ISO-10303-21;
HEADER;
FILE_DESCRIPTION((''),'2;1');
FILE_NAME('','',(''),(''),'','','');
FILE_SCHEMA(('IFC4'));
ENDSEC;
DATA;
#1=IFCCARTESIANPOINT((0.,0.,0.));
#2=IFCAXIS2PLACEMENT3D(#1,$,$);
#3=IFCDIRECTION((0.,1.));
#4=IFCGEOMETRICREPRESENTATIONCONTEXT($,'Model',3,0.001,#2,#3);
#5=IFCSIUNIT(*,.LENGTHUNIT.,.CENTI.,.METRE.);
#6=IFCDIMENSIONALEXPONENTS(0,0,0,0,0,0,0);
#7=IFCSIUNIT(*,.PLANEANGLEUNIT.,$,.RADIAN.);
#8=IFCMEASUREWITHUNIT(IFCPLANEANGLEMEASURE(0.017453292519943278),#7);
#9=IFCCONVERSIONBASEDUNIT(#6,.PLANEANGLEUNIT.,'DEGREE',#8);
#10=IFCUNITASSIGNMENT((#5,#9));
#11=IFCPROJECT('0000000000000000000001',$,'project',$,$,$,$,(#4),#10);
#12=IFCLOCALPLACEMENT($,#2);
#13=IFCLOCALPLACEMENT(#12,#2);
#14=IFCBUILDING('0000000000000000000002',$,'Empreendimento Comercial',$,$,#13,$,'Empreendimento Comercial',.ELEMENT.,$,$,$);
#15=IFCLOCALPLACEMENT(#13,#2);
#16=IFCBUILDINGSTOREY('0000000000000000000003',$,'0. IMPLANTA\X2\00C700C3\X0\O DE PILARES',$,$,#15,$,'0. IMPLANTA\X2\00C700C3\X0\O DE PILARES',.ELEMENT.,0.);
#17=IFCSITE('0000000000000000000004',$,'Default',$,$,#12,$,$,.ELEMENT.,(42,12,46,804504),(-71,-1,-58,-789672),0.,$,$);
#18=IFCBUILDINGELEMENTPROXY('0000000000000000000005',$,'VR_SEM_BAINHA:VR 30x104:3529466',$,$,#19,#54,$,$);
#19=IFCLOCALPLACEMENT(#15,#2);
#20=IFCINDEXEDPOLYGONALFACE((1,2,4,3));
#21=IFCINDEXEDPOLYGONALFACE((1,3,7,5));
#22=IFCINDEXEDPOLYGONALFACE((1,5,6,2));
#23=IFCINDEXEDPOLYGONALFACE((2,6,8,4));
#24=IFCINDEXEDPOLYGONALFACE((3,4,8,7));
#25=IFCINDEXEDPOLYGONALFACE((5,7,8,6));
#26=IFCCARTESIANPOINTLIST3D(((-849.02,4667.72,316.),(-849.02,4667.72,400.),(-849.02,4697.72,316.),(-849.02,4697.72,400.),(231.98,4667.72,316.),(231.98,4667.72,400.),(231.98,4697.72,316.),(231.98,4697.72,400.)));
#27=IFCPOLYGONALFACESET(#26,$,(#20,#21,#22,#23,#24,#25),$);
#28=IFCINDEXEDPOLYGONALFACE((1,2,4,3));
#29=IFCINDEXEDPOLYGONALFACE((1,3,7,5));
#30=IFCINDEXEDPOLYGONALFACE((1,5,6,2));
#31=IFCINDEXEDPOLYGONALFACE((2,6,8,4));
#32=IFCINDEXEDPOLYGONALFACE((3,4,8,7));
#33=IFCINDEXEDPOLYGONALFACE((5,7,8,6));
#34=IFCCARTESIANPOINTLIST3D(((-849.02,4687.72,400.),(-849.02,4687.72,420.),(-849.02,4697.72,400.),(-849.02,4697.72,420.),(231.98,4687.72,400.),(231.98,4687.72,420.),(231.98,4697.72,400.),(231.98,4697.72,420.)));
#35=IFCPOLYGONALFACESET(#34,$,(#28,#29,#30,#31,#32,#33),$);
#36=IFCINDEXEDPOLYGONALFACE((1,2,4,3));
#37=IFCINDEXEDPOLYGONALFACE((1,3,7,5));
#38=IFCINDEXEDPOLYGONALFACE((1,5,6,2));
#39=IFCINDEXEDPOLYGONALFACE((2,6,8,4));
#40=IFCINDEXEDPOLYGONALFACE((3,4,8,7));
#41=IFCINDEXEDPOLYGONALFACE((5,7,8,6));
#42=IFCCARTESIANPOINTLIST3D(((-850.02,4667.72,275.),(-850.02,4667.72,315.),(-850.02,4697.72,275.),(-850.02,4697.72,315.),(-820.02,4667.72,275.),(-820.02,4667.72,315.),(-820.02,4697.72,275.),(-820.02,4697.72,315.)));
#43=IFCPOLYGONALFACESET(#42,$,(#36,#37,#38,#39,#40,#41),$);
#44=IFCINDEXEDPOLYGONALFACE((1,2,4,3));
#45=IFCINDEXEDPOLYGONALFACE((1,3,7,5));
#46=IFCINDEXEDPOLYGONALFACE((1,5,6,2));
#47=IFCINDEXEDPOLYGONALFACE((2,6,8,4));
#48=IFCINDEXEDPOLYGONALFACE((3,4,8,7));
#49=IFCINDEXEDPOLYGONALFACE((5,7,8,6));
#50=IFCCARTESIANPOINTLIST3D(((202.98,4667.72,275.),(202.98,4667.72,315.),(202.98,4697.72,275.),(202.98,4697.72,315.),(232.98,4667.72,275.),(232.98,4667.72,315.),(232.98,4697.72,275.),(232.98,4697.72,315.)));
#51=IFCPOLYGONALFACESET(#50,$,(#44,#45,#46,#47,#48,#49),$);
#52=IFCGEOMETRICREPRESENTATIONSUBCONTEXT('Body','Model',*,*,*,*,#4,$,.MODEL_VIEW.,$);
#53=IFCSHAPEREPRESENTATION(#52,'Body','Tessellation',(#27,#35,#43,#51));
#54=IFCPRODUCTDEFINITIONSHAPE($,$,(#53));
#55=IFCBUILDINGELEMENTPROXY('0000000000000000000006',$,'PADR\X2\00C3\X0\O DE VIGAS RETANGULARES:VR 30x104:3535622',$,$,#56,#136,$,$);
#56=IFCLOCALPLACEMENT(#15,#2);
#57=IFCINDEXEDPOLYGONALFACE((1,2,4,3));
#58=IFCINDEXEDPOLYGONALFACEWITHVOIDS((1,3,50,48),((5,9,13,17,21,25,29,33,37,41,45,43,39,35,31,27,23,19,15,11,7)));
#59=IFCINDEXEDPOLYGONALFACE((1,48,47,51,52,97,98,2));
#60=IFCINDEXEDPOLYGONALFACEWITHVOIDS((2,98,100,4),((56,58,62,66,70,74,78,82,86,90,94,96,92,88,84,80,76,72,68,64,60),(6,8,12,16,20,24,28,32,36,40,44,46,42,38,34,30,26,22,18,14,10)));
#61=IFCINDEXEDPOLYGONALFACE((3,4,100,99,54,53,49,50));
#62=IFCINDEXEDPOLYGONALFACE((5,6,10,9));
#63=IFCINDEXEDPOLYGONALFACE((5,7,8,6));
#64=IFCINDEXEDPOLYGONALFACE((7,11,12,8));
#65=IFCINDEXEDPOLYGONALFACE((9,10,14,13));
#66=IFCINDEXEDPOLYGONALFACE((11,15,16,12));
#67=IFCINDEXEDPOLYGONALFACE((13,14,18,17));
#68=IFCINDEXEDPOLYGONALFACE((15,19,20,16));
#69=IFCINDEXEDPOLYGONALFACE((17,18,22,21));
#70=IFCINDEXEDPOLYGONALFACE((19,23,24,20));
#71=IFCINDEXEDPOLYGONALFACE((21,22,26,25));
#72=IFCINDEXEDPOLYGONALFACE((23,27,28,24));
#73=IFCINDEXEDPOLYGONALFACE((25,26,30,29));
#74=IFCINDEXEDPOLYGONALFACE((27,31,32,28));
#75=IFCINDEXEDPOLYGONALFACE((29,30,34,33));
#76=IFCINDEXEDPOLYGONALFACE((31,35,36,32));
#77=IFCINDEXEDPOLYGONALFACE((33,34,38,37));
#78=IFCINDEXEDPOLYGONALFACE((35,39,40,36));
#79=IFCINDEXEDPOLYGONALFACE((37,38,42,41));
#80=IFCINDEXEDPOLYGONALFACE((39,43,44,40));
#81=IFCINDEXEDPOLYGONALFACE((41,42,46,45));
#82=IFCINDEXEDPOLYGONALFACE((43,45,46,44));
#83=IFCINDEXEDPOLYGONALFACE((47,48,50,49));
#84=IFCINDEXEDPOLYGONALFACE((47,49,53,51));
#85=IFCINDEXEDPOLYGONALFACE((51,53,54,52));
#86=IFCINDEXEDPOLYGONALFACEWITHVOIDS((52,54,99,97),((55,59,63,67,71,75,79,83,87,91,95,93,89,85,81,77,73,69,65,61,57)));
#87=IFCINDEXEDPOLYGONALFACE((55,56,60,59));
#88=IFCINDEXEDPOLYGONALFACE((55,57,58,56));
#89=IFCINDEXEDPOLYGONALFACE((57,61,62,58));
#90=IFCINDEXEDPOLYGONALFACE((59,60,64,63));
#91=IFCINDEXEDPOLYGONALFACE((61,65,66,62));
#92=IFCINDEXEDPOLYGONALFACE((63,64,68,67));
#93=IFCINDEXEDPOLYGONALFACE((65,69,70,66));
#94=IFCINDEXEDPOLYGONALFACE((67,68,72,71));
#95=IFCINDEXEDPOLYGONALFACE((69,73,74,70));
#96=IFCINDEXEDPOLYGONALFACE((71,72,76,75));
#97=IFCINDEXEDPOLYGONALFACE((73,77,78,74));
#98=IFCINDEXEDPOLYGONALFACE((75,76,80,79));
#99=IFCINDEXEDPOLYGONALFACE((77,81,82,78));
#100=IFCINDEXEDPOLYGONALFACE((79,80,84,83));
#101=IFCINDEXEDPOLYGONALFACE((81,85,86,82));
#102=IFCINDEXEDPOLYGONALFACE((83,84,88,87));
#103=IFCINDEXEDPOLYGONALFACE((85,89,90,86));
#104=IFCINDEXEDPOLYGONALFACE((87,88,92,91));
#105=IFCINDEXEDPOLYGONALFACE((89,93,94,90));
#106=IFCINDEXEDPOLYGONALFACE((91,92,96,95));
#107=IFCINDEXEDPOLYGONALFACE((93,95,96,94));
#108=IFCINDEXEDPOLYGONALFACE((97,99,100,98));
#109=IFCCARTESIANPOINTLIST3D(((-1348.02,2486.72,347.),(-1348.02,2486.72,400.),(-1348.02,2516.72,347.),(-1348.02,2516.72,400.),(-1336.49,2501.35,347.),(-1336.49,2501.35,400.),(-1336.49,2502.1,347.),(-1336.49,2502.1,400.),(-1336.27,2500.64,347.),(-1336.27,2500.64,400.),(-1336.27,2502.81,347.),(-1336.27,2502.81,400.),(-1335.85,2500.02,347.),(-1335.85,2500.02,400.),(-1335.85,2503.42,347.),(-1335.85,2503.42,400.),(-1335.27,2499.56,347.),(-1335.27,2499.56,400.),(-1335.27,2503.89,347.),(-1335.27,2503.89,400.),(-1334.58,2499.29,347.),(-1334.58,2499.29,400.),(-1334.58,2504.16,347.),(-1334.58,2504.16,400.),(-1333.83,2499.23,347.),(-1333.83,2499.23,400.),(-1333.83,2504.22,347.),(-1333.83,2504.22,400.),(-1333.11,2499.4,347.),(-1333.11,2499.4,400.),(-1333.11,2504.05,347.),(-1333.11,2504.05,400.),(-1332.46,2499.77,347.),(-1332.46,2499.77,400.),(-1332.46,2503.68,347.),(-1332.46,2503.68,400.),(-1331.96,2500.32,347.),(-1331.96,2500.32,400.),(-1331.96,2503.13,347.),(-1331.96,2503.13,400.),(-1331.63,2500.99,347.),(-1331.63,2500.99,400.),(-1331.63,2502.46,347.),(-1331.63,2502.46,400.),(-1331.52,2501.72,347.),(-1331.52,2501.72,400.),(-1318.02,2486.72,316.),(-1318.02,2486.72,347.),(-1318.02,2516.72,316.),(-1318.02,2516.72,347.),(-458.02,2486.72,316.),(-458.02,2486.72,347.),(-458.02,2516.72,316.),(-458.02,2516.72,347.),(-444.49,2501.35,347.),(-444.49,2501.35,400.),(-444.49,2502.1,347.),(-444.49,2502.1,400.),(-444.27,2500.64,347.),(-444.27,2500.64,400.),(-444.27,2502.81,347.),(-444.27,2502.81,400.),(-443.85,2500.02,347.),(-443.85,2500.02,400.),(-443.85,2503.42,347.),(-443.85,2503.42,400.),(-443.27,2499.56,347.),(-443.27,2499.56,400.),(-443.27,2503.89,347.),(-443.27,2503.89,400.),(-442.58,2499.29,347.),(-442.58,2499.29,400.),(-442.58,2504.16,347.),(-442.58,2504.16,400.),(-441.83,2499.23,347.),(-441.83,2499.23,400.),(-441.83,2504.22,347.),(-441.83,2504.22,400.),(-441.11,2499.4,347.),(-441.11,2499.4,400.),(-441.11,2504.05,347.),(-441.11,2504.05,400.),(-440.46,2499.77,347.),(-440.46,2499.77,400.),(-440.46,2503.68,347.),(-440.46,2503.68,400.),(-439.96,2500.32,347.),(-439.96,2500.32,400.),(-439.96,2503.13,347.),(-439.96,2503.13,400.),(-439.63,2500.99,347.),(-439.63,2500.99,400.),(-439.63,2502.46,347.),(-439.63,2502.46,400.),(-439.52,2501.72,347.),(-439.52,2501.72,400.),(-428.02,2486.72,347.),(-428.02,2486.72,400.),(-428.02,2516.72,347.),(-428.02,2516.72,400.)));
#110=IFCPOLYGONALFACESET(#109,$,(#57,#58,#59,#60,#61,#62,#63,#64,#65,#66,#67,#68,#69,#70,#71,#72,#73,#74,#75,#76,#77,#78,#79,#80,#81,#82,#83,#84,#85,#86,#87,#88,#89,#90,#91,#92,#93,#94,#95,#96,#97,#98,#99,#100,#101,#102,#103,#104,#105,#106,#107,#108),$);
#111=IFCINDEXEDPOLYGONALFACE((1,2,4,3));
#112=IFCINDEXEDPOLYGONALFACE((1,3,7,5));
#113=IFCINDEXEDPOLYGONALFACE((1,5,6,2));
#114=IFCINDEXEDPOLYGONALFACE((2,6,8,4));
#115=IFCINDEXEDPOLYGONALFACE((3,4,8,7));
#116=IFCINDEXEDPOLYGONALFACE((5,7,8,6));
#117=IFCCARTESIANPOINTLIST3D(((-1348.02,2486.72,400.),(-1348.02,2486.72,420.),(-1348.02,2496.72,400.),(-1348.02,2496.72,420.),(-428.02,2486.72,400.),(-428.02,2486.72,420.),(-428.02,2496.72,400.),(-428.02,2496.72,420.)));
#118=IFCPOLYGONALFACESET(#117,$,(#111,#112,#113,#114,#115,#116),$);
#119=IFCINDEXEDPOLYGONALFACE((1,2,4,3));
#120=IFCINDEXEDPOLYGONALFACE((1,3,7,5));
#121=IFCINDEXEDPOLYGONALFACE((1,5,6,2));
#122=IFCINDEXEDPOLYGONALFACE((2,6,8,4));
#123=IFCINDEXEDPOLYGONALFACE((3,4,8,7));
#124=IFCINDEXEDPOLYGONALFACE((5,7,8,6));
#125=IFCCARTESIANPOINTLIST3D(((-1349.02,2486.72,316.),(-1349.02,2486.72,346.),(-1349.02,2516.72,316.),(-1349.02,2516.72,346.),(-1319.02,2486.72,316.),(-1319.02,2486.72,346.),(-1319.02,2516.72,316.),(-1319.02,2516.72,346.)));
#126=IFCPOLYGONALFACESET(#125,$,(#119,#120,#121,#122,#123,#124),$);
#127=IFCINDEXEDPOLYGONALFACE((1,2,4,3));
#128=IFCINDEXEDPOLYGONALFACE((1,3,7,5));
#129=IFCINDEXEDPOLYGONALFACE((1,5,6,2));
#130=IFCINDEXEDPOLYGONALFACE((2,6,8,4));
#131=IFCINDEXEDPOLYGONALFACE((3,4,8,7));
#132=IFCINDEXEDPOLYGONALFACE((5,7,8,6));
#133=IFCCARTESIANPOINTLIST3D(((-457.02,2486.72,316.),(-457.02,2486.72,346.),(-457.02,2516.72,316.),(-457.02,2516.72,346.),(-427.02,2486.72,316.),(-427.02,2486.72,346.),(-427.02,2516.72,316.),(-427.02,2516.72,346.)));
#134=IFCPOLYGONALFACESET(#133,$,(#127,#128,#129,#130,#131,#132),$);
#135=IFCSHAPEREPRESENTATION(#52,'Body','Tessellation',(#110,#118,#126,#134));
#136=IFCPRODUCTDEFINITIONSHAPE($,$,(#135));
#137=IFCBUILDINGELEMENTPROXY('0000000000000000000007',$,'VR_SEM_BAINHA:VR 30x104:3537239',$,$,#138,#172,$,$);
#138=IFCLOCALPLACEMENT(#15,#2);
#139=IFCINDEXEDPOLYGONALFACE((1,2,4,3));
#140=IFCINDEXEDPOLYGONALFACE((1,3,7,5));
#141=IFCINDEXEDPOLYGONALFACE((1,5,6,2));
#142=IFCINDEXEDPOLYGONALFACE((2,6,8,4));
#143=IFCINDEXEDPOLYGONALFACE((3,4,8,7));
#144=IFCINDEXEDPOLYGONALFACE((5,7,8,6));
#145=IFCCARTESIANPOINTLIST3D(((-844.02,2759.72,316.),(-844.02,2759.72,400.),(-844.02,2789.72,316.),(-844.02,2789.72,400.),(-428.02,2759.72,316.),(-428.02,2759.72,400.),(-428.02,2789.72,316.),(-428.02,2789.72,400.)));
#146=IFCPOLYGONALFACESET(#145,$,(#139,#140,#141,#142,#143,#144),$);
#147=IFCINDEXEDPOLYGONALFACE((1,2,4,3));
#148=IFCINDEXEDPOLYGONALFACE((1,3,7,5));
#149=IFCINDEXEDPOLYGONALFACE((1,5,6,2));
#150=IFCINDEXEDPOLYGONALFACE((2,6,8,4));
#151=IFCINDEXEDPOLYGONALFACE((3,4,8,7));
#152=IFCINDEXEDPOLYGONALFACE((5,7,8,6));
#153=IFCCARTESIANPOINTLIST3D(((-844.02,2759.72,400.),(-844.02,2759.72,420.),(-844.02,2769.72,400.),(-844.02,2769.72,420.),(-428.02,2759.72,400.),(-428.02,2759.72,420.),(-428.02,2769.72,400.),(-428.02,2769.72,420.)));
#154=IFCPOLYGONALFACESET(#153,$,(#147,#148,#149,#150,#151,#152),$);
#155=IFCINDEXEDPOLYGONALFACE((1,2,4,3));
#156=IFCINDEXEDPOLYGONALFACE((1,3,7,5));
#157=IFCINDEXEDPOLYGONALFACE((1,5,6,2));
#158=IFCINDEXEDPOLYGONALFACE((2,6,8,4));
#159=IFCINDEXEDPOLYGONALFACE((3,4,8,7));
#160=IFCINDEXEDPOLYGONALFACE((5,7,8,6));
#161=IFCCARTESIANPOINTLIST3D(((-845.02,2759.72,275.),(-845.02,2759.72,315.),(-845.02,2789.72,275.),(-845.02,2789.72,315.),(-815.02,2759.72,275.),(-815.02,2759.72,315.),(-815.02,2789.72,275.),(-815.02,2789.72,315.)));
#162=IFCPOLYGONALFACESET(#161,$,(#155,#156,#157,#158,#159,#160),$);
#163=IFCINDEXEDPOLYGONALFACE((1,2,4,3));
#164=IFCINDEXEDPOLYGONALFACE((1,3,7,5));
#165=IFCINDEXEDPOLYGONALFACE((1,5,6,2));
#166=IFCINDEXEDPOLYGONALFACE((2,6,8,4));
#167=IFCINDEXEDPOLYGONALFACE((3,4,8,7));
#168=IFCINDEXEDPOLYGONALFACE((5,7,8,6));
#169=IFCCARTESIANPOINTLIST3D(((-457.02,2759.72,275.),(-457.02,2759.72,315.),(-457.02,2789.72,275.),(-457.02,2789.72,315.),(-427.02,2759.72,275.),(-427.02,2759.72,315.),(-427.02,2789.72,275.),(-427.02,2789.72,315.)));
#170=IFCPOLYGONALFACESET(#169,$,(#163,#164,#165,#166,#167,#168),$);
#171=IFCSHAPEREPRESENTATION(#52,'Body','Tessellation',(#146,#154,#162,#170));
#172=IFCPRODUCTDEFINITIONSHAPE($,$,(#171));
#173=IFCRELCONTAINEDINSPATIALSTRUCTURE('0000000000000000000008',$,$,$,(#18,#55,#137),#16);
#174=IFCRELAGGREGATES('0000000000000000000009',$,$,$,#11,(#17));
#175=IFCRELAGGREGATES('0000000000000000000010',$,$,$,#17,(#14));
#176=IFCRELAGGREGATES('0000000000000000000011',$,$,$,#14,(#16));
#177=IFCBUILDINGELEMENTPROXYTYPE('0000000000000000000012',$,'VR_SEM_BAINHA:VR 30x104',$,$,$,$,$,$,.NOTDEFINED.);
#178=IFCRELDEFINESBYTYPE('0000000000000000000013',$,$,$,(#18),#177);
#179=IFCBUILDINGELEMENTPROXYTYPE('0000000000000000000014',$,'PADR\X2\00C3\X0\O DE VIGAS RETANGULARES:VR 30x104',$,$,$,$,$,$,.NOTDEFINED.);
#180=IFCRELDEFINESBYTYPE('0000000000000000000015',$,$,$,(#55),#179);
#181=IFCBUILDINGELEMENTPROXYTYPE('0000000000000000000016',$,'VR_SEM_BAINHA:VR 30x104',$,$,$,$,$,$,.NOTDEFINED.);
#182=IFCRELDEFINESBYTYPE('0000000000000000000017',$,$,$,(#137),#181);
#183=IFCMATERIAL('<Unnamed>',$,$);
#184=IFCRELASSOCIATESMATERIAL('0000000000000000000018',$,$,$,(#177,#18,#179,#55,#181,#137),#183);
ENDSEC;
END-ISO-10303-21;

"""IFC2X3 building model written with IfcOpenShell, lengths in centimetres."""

from ifc_helpers import new_model, entity, si_unit, converted_unit, direction, frame, frame_2d, origin, origin_2d_with_axis, place, context, subcontext, project, spatial, polyline, rectangle, circle, outline, extrude, source, transform, mapped, material, type_object, type_shapes, element, save


model = new_model("IFC2X3")

# Units and contexts
model_context = context("Model", 3, precision=0.001, world=origin(), true_north=direction((0.0, 1.0)))
body_context = subcontext(model_context, "Body", "Model", "MODEL_VIEW")
ifc_project = project(units=[si_unit("LENGTHUNIT", "METRE", prefix="CENTI"), converted_unit("PLANEANGLEUNIT", "DEGREE", entity("IfcPlaneAngleMeasure", 0.017453292519943278), si_unit("PLANEANGLEUNIT", "RADIAN"), dimensions=[0, 0, 0, 0, 0, 0, 0])], contexts=[model_context])

# Site, building, storey
site_placement = place(None, origin())
site = spatial("IfcSite", under=ifc_project, at=site_placement, Name="Default", CompositionType="ELEMENT", RefLatitude=(42, 12, 46, 804504), RefLongitude=(-71, -1, -58, -789672), RefElevation=0.0)
building_placement = place(site_placement, origin())
building = spatial("IfcBuilding", under=site, at=building_placement, Name="Empreendimento Comercial", LongName="Empreendimento Comercial", CompositionType="ELEMENT")
storey_placement = place(building_placement, origin())
storey = spatial("IfcBuildingStorey", under=building, at=storey_placement, Name="0. IMPLANTAÇÃO DE PILARES", LongName="0. IMPLANTAÇÃO DE PILARES", CompositionType="ELEMENT", Elevation=0.0)

# Building element proxy
ifc_material_1 = material(Name="<Unnamed>")
building_element_proxy_type_1 = type_object("IfcBuildingElementProxyType", Name="VR_SEM_BAINHA:VR 30x104", PredefinedType="NOTDEFINED", material=ifc_material_1)
shared_shape_1 = source(origin(), body_context, "Body", "SweptSolid", [
    extrude(rectangle(XDim=1081.0, YDim=30.0, at=origin_2d_with_axis()), frame((-308.52, 4682.72, 316.0), z_axis=(0.0, 0.0, 1.0), x_axis=(-1.0, 0.0, 0.0)), (0.0, 0.0, 1.0), 84.0),
    extrude(rectangle(XDim=1081.0, YDim=10.0, at=frame_2d((0.0, 0.0), x_axis=(1.0, 0.0))), frame((-308.52, 4692.72, 400.0), z_axis=(0.0, 0.0, 1.0), x_axis=(-1.0, 0.0, 0.0)), (0.0, 0.0, 1.0), 20.0),
    extrude(rectangle(XDim=30.0, YDim=30.0, at=origin_2d_with_axis()), frame((-835.02, 4682.72, 275.0), z_axis=(0.0, 0.0, 1.0), x_axis=(0.0, 1.0, 0.0)), (0.0, 0.0, 1.0), 40.0),
    extrude(rectangle(XDim=30.0, YDim=30.0, at=origin_2d_with_axis()), frame((217.98, 4682.72, 275.0), z_axis=(0.0, 0.0, 1.0), x_axis=(0.0, 1.0, 0.0)), (0.0, 0.0, 1.0), 40.0),
])
type_shapes(building_element_proxy_type_1, [shared_shape_1])
proxy_1_placement = place(storey_placement, origin())
element("IfcBuildingElementProxy", 1, at=proxy_1_placement, inside=storey, type_object=building_element_proxy_type_1, material=ifc_material_1, Name="VR_SEM_BAINHA:VR 30x104:3529466", context=body_context, shape_type="MappedRepresentation", body=[
    mapped(shared_shape_1, transform((0.0, 0.0, 0.0), scale=1.0)),
])

# Building element proxy, openings
building_element_proxy_type_2 = type_object("IfcBuildingElementProxyType", Name="PADRÃO DE VIGAS RETANGULARES:VR 30x104", PredefinedType="NOTDEFINED", material=ifc_material_1)
shared_shape_2 = source(origin(), body_context, "Body", "SweptSolid", [
    extrude(outline(polyline([(-460.0, -47.5), (460.0, -47.5), (460.0, 5.5), (430.0, 5.5), (430.0, 36.5), (-430.0, 36.5), (-430.0, 5.5), (-460.0, 5.5), (-460.0, -47.5)])), frame((-888.02, 2486.72, 352.5), z_axis=(0.0, 1.0, 0.0), x_axis=(1.0, 0.0, 0.0)), (0.0, 0.0, 1.0), 30.0),
    extrude(rectangle(XDim=10.0, YDim=920.0, at=frame_2d((0.0, 0.0), x_axis=(1.0, 0.0))), frame((-888.02, 2491.72, 400.0), z_axis=(0.0, 0.0, 1.0), x_axis=(0.0, 1.0, 0.0)), (0.0, 0.0, 1.0), 20.0),
    extrude(rectangle(XDim=30.0, YDim=30.0, at=frame_2d((0.0, 0.0), x_axis=(1.0, 0.0))), frame((-1334.02, 2501.72, 316.0), z_axis=(0.0, 0.0, 1.0), x_axis=(-1.0, 0.0, 0.0)), (0.0, 0.0, 1.0), 30.0),
    extrude(rectangle(XDim=30.0, YDim=30.0, at=origin_2d_with_axis()), frame((-442.02, 2501.72, 316.0), z_axis=(0.0, 0.0, 1.0), x_axis=(-1.0, 0.0, 0.0)), (0.0, 0.0, 1.0), 30.0),
])
type_shapes(building_element_proxy_type_2, [shared_shape_2])
proxy_2_placement = place(storey_placement, origin())
proxy_2 = element("IfcBuildingElementProxy", 2, at=proxy_2_placement, inside=storey, type_object=building_element_proxy_type_2, material=ifc_material_1, Name="PADRÃO DE VIGAS RETANGULARES:VR 30x104:3535622", context=body_context, shape_type="MappedRepresentation", body=[
    mapped(shared_shape_2, transform((0.0, 0.0, 0.0), scale=1.0)),
])
opening_1_placement = place(storey_placement, origin())
element("IfcOpeningElement", 3, at=opening_1_placement, cuts=proxy_2, ObjectType="Opening", context=body_context, shape_type="SweptSolid", body=[
    extrude(circle(Radius=2.5, at=origin_2d_with_axis()), frame((-442.02, 2501.72, 400.0), z_axis=(0.0, 0.0, -1.0), x_axis=(1.0, 0.0, 0.0)), (0.0, 0.0, 1.0), 53.0),
])
opening_2_placement = place(storey_placement, origin())
element("IfcOpeningElement", 4, at=opening_2_placement, cuts=proxy_2, ObjectType="Opening", context=body_context, shape_type="SweptSolid", body=[
    extrude(circle(Radius=2.5, at=origin_2d_with_axis()), frame((-1334.02, 2501.72, 347.0)), (0.0, 0.0, 1.0), 53.0),
])

# Building element proxy
building_element_proxy_type_3 = type_object("IfcBuildingElementProxyType", Name="VR_SEM_BAINHA:VR 30x104", PredefinedType="NOTDEFINED", material=ifc_material_1)
shared_shape_3 = source(origin(), body_context, "Body", "SweptSolid", [
    extrude(rectangle(XDim=30.0, YDim=416.0, at=frame_2d((5.0, 8.0), x_axis=(1.0, 0.0))), frame((-628.02, 2769.72, 316.0), z_axis=(0.0, 0.0, 1.0), x_axis=(0.0, 1.0, 0.0)), (0.0, 0.0, 1.0), 84.0),
    extrude(rectangle(XDim=10.0, YDim=416.0, at=frame_2d((0.0, 0.0), x_axis=(1.0, 0.0))), frame((-636.02, 2764.72, 400.0), z_axis=(0.0, 0.0, 1.0), x_axis=(0.0, 1.0, 0.0)), (0.0, 0.0, 1.0), 20.0),
    extrude(rectangle(XDim=30.0, YDim=30.0, at=frame_2d((0.0, 0.0), x_axis=(1.0, 0.0))), frame((-830.02, 2774.72, 275.0), z_axis=(0.0, 0.0, 1.0), x_axis=(-1.0, 0.0, 0.0)), (0.0, 0.0, 1.0), 40.0),
    extrude(rectangle(XDim=30.0, YDim=30.0, at=frame_2d((0.0, 0.0), x_axis=(1.0, 0.0))), frame((-442.02, 2774.72, 275.0), z_axis=(0.0, 0.0, 1.0), x_axis=(-1.0, 0.0, 0.0)), (0.0, 0.0, 1.0), 40.0),
])
type_shapes(building_element_proxy_type_3, [shared_shape_3])
proxy_3_placement = place(storey_placement, origin())
element("IfcBuildingElementProxy", 5, at=proxy_3_placement, inside=storey, type_object=building_element_proxy_type_3, material=ifc_material_1, Name="VR_SEM_BAINHA:VR 30x104:3537239", context=body_context, shape_type="MappedRepresentation", body=[
    mapped(shared_shape_3, transform((0.0, 0.0, 0.0), scale=1.0)),
])

save(model, "model.ifc")
